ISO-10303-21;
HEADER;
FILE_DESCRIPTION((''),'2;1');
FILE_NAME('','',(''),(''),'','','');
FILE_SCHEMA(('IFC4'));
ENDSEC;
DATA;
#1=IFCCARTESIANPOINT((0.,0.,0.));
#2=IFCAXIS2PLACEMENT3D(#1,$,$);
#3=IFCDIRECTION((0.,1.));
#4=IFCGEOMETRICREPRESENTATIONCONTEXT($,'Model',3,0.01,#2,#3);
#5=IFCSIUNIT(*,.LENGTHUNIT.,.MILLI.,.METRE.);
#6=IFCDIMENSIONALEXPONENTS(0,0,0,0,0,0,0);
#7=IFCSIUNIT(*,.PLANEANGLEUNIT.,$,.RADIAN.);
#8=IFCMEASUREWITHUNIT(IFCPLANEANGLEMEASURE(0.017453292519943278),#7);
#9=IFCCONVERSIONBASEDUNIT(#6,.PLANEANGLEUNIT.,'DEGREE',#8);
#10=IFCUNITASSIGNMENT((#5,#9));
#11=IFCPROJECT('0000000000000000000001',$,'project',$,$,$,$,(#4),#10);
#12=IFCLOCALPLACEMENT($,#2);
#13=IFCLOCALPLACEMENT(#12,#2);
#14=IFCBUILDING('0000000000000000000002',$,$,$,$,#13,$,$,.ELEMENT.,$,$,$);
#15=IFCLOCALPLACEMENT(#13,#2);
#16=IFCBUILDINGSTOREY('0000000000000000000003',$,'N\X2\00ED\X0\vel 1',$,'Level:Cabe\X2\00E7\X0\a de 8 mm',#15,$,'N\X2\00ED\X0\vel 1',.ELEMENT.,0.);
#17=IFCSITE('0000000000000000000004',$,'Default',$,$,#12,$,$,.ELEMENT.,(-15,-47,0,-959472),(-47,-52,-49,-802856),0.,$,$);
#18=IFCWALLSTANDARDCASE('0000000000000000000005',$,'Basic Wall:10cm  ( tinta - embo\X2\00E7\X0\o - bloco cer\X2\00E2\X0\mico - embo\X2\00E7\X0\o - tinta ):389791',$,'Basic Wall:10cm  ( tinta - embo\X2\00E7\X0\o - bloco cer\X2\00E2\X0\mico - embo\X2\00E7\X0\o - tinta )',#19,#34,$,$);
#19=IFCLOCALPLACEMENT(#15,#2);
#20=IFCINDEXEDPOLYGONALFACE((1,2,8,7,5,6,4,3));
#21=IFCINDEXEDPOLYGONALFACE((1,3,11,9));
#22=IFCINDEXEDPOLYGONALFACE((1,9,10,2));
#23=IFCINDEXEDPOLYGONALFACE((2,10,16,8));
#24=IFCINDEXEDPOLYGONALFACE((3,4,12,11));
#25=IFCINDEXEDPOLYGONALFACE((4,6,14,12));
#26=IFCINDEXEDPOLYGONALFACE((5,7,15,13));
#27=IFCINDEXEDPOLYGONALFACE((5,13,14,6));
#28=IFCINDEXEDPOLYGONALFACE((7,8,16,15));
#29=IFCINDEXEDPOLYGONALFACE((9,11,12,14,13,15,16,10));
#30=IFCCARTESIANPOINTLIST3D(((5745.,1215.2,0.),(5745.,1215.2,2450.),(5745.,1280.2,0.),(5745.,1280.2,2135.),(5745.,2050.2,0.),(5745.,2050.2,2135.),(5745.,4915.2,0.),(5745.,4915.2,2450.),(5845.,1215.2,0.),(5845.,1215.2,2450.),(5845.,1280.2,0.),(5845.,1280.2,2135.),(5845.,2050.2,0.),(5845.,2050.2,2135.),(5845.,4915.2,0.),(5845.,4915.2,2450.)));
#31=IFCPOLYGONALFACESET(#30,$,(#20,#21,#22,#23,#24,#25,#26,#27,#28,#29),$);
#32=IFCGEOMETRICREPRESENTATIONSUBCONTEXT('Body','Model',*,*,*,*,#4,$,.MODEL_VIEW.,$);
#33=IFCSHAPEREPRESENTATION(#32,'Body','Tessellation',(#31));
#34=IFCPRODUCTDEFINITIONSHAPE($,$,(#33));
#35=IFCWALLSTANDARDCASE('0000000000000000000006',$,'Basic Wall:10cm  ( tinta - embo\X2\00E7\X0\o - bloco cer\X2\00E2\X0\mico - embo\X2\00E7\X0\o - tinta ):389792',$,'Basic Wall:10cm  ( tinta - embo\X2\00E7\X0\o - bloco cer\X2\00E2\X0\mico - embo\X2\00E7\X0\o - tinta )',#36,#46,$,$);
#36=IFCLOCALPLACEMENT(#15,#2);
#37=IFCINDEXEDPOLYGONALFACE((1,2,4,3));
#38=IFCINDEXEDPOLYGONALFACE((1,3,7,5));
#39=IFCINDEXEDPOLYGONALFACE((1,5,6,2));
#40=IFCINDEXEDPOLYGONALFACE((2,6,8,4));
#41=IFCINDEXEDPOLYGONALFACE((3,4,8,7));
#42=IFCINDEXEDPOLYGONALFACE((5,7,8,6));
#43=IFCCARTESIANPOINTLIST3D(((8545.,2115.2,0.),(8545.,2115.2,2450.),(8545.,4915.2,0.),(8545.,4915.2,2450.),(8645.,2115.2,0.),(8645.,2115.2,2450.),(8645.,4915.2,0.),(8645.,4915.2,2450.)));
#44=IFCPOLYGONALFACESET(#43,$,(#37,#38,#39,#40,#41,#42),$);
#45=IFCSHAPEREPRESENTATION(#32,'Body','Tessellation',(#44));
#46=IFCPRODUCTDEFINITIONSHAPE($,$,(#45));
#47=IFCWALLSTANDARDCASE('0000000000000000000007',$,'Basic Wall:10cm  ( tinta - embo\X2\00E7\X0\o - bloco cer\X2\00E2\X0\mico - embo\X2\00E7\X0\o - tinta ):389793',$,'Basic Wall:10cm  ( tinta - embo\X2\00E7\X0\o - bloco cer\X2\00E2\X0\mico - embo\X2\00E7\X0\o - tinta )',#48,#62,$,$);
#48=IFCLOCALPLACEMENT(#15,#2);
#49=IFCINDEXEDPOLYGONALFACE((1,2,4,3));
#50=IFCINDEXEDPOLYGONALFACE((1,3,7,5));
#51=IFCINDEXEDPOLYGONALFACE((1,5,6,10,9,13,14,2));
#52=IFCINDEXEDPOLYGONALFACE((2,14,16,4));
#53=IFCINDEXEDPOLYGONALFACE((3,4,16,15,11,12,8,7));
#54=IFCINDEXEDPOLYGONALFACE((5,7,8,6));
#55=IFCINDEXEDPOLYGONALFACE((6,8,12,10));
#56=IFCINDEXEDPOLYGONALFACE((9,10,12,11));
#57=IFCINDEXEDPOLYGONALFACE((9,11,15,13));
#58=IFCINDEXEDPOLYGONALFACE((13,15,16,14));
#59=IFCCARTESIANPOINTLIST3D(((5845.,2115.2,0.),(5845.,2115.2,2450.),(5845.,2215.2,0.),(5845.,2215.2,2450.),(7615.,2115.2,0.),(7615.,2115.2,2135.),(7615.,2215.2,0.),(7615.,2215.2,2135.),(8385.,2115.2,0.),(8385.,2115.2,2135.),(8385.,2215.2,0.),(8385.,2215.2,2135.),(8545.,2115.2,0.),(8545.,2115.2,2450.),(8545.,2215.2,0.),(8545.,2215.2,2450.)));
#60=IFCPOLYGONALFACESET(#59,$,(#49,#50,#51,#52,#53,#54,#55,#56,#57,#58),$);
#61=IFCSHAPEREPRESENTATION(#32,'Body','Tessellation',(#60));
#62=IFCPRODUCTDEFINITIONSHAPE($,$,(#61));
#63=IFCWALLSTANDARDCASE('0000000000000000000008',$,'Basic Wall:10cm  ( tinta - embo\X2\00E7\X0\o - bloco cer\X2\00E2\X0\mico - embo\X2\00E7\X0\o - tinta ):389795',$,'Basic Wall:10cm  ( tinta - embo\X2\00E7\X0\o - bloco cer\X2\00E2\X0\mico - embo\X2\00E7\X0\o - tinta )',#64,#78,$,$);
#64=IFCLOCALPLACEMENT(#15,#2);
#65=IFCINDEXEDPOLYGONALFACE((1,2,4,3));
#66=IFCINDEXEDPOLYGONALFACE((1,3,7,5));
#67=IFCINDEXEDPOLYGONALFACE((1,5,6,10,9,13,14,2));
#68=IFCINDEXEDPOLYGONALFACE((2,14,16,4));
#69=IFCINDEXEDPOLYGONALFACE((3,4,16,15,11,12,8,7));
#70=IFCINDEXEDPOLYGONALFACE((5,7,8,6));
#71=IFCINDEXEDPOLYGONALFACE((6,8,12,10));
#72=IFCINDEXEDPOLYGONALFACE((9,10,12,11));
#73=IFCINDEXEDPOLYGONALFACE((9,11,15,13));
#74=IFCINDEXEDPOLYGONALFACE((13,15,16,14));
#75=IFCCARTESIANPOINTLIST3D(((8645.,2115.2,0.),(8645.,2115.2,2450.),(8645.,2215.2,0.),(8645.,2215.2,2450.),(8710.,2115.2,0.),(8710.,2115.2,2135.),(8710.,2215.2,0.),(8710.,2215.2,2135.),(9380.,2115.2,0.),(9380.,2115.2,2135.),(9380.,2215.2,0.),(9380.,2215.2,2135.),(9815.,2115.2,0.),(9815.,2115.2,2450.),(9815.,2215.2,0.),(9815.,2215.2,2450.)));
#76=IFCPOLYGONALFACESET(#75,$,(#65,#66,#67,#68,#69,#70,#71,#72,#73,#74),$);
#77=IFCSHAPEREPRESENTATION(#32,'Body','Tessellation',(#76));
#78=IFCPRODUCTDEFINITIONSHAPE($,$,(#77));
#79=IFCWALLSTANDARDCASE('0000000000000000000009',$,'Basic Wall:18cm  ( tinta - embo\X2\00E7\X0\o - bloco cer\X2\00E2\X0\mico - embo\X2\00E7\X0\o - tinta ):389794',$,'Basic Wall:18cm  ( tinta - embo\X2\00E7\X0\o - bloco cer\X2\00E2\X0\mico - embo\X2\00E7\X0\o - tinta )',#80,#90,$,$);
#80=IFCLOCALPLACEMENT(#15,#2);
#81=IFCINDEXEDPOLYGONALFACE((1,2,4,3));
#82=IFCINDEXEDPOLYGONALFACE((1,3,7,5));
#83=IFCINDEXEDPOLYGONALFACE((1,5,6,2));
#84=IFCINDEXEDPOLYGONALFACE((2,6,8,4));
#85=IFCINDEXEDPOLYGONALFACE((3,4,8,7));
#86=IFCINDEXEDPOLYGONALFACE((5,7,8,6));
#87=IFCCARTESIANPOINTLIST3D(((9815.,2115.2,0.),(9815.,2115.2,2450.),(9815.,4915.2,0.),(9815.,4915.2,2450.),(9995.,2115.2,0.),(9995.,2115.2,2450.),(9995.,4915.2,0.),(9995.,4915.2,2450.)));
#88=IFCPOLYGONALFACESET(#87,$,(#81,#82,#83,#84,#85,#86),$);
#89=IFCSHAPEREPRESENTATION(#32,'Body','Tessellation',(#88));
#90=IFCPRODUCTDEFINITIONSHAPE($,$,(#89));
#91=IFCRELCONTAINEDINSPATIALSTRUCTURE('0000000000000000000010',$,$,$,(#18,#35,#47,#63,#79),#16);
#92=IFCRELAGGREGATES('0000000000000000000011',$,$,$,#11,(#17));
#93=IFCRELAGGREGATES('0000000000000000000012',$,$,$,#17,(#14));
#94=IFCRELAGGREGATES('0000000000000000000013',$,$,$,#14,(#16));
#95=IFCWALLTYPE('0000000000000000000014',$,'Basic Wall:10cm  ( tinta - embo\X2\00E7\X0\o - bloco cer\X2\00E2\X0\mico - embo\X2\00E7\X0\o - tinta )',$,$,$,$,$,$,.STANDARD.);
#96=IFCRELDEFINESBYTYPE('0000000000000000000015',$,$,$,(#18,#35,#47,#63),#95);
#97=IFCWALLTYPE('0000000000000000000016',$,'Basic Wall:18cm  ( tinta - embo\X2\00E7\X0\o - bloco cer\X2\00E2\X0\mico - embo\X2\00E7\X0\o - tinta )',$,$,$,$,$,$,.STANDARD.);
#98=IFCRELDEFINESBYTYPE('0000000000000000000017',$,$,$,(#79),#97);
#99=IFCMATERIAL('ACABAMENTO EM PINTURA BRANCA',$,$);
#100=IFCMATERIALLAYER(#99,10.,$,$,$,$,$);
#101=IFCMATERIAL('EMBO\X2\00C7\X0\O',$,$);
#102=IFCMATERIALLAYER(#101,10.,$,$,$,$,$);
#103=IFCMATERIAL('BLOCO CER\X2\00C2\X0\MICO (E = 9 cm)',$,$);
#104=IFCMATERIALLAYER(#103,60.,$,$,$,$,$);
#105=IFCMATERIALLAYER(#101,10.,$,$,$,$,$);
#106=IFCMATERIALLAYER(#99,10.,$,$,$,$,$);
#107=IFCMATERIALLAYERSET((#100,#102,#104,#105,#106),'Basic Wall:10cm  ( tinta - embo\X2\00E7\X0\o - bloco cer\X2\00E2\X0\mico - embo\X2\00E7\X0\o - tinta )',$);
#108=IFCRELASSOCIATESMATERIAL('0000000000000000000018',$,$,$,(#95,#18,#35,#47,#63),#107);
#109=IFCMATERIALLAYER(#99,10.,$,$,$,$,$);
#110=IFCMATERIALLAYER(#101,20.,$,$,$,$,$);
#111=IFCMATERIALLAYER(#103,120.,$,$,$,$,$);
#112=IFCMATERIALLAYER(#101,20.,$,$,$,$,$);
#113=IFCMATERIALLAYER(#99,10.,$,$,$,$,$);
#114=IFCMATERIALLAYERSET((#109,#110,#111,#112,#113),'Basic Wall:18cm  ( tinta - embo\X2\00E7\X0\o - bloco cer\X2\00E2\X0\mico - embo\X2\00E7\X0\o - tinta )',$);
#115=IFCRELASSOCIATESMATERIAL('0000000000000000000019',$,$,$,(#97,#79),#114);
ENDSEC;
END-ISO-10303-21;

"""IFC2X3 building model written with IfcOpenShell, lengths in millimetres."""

from ifc_helpers import new_model, entity, si_unit, converted_unit, direction, frame, frame_2d, origin, place, context, subcontext, project, spatial, rectangle, extrude, material, layer, layer_set, layer_usage, type_object, element, save


model = new_model("IFC2X3")

# Units and contexts
model_context = context("Model", 3, precision=0.01, world=origin(), true_north=direction((0.0, 1.0)))
body_context = subcontext(model_context, "Body", "Model", "MODEL_VIEW")
ifc_project = project(units=[si_unit("LENGTHUNIT", "METRE", prefix="MILLI"), converted_unit("PLANEANGLEUNIT", "DEGREE", entity("IfcPlaneAngleMeasure", 0.017453292519943278), si_unit("PLANEANGLEUNIT", "RADIAN"), dimensions=[0, 0, 0, 0, 0, 0, 0])], contexts=[model_context])

# Site, building, storey
site_placement = place(None, origin())
site = spatial("IfcSite", under=ifc_project, at=site_placement, Name="Default", CompositionType="ELEMENT", RefLatitude=(-15, -47, 0, -959472), RefLongitude=(-47, -52, -49, -802856), RefElevation=0.0)
building_placement = place(site_placement, origin())
building = spatial("IfcBuilding", under=site, at=building_placement, CompositionType="ELEMENT")
storey_placement = place(building_placement, origin())
storey = spatial("IfcBuildingStorey", under=building, at=storey_placement, Name="Nível 1", ObjectType="Level:Cabeça de 8 mm", LongName="Nível 1", CompositionType="ELEMENT", Elevation=0.0)

# Shared definitions
ifc_material_1 = material(Name="ACABAMENTO EM PINTURA BRANCA")
ifc_material_2 = material(Name="EMBOÇO")
ifc_material_3 = material(Name="BLOCO CERÂMICO (E = 9 cm)")

# Wall, opening
ifc_layer_1 = layer(ifc_material_1, 10.0)
ifc_layer_2 = layer(ifc_material_2, 10.0)
ifc_layer_3 = layer(ifc_material_3, 60.0)
ifc_layer_4 = layer(ifc_material_2, 10.0)
ifc_layer_5 = layer(ifc_material_1, 10.0)
ifc_layer_set_1 = layer_set([ifc_layer_1, ifc_layer_2, ifc_layer_3, ifc_layer_4, ifc_layer_5], Name="Basic Wall:10cm  ( tinta - emboço - bloco cerâmico - emboço - tinta )")
ifc_layer_usage_1 = layer_usage(ifc_layer_set_1, "AXIS2", "NEGATIVE", 50.0)
wall_type_1 = type_object("IfcWallType", Name="Basic Wall:10cm  ( tinta - emboço - bloco cerâmico - emboço - tinta )", PredefinedType="STANDARD", material=ifc_layer_set_1)
wall_1_placement = place(storey_placement, frame((5795.0, 4915.2, 0.0), z_axis=(0.0, 0.0, 1.0), x_axis=(0.0, -1.0, 0.0)))
wall_1 = element("IfcWallStandardCase", 1, at=wall_1_placement, inside=storey, type_object=wall_type_1, material=ifc_layer_usage_1, Name="Basic Wall:10cm  ( tinta - emboço - bloco cerâmico - emboço - tinta ):389791", ObjectType="Basic Wall:10cm  ( tinta - emboço - bloco cerâmico - emboço - tinta )", context=body_context, shape_type="SweptSolid", body=[
    extrude(rectangle(XDim=3700.0, YDim=100.0, at=frame_2d((1850.0, 0.0), x_axis=(1.0, 0.0))), origin(), (0.0, 0.0, 1.0), 2450.0),
])
opening_1_placement = place(wall_1_placement, frame((4915.2, -5795.0, 0.0), z_axis=(0.0, 0.0, 1.0), x_axis=(0.0, 1.0, 0.0)))
element("IfcOpeningElement", 2, at=opening_1_placement, cuts=wall_1, ObjectType="Opening", context=body_context, shape_type="SweptSolid", body=[
    extrude(rectangle(XDim=2135.0, YDim=770.0, at=frame_2d((0.0, 0.0), x_axis=(0.0, 1.0))), frame((5345.0, 1665.2, 1067.5), z_axis=(1.0, 0.0, 0.0), x_axis=(0.0, -1.0, 0.0)), (0.0, 0.0, 1.0), 500.0),
])

# Wall
ifc_layer_usage_2 = layer_usage(ifc_layer_set_1, "AXIS2", "NEGATIVE", 50.0)
wall_2_placement = place(storey_placement, frame((8595.0, 2115.2, 0.0), z_axis=(0.0, 0.0, 1.0), x_axis=(0.0, 1.0, 0.0)))
element("IfcWallStandardCase", 3, at=wall_2_placement, inside=storey, type_object=wall_type_1, material=ifc_layer_usage_2, Name="Basic Wall:10cm  ( tinta - emboço - bloco cerâmico - emboço - tinta ):389792", ObjectType="Basic Wall:10cm  ( tinta - emboço - bloco cerâmico - emboço - tinta )", context=body_context, shape_type="SweptSolid", body=[
    extrude(rectangle(XDim=2800.0, YDim=100.0, at=frame_2d((1400.0, 0.0), x_axis=(-1.0, 0.0))), origin(), (0.0, 0.0, 1.0), 2450.0),
])

# Walls, openings
ifc_layer_usage_3 = layer_usage(ifc_layer_set_1, "AXIS2", "NEGATIVE", 50.0)
wall_3_placement = place(storey_placement, frame((5845.0, 2165.2, 0.0)))
wall_3 = element("IfcWallStandardCase", 4, at=wall_3_placement, inside=storey, type_object=wall_type_1, material=ifc_layer_usage_3, Name="Basic Wall:10cm  ( tinta - emboço - bloco cerâmico - emboço - tinta ):389793", ObjectType="Basic Wall:10cm  ( tinta - emboço - bloco cerâmico - emboço - tinta )", context=body_context, shape_type="SweptSolid", body=[
    extrude(rectangle(XDim=2700.0, YDim=100.0, at=frame_2d((1350.0, 0.0), x_axis=(1.0, 0.0))), origin(), (0.0, 0.0, 1.0), 2450.0),
])
opening_2_placement = place(wall_3_placement, frame((-5845.0, -2165.2, 0.0)))
element("IfcOpeningElement", 5, at=opening_2_placement, cuts=wall_3, ObjectType="Opening", context=body_context, shape_type="SweptSolid", body=[
    extrude(rectangle(XDim=2135.0, YDim=770.0, at=frame_2d((0.0, 0.0), x_axis=(0.0, 1.0))), frame((8000.0, 2115.2, 1067.5), z_axis=(0.0, 1.0, 0.0), x_axis=(1.0, 0.0, 0.0)), (0.0, 0.0, 1.0), 500.0),
])
ifc_layer_usage_4 = layer_usage(ifc_layer_set_1, "AXIS2", "NEGATIVE", 50.0)
wall_4_placement = place(storey_placement, frame((9815.0, 2165.2, 0.0), z_axis=(0.0, 0.0, 1.0), x_axis=(-1.0, 0.0, 0.0)))
wall_4 = element("IfcWallStandardCase", 6, at=wall_4_placement, inside=storey, type_object=wall_type_1, material=ifc_layer_usage_4, Name="Basic Wall:10cm  ( tinta - emboço - bloco cerâmico - emboço - tinta ):389795", ObjectType="Basic Wall:10cm  ( tinta - emboço - bloco cerâmico - emboço - tinta )", context=body_context, shape_type="SweptSolid", body=[
    extrude(rectangle(XDim=1170.0, YDim=100.0, at=frame_2d((585.0, 0.0), x_axis=(-1.0, 0.0))), origin(), (0.0, 0.0, 1.0), 2450.0),
])
opening_3_placement = place(wall_4_placement, frame((9815.0, 2165.2, 0.0), z_axis=(0.0, 0.0, 1.0), x_axis=(-1.0, 0.0, 0.0)))
element("IfcOpeningElement", 7, at=opening_3_placement, cuts=wall_4, ObjectType="Opening", context=body_context, shape_type="SweptSolid", body=[
    extrude(rectangle(XDim=2135.0, YDim=670.0, at=frame_2d((0.0, 0.0), x_axis=(0.0, 1.0))), frame((9045.0, 2615.2, 1067.5), z_axis=(0.0, -1.0, 0.0), x_axis=(-1.0, 0.0, 0.0)), (0.0, 0.0, 1.0), 500.0),
])

# Wall
ifc_layer_6 = layer(ifc_material_1, 10.0)
ifc_layer_7 = layer(ifc_material_2, 20.0)
ifc_layer_8 = layer(ifc_material_3, 120.0)
ifc_layer_9 = layer(ifc_material_2, 20.0)
ifc_layer_10 = layer(ifc_material_1, 10.0)
ifc_layer_set_2 = layer_set([ifc_layer_6, ifc_layer_7, ifc_layer_8, ifc_layer_9, ifc_layer_10], Name="Basic Wall:18cm  ( tinta - emboço - bloco cerâmico - emboço - tinta )")
ifc_layer_usage_5 = layer_usage(ifc_layer_set_2, "AXIS2", "NEGATIVE", 90.0)
wall_type_2 = type_object("IfcWallType", Name="Basic Wall:18cm  ( tinta - emboço - bloco cerâmico - emboço - tinta )", PredefinedType="STANDARD", material=ifc_layer_set_2)
wall_5_placement = place(storey_placement, frame((9905.0, 4915.2, 0.0), z_axis=(0.0, 0.0, 1.0), x_axis=(0.0, -1.0, 0.0)))
element("IfcWallStandardCase", 8, at=wall_5_placement, inside=storey, type_object=wall_type_2, material=ifc_layer_usage_5, Name="Basic Wall:18cm  ( tinta - emboço - bloco cerâmico - emboço - tinta ):389794", ObjectType="Basic Wall:18cm  ( tinta - emboço - bloco cerâmico - emboço - tinta )", context=body_context, shape_type="SweptSolid", body=[
    extrude(rectangle(XDim=2800.0, YDim=180.0, at=frame_2d((1400.0, 0.0), x_axis=(-1.0, 0.0))), origin(), (0.0, 0.0, 1.0), 2450.0),
])

save(model, "model.ifc")
